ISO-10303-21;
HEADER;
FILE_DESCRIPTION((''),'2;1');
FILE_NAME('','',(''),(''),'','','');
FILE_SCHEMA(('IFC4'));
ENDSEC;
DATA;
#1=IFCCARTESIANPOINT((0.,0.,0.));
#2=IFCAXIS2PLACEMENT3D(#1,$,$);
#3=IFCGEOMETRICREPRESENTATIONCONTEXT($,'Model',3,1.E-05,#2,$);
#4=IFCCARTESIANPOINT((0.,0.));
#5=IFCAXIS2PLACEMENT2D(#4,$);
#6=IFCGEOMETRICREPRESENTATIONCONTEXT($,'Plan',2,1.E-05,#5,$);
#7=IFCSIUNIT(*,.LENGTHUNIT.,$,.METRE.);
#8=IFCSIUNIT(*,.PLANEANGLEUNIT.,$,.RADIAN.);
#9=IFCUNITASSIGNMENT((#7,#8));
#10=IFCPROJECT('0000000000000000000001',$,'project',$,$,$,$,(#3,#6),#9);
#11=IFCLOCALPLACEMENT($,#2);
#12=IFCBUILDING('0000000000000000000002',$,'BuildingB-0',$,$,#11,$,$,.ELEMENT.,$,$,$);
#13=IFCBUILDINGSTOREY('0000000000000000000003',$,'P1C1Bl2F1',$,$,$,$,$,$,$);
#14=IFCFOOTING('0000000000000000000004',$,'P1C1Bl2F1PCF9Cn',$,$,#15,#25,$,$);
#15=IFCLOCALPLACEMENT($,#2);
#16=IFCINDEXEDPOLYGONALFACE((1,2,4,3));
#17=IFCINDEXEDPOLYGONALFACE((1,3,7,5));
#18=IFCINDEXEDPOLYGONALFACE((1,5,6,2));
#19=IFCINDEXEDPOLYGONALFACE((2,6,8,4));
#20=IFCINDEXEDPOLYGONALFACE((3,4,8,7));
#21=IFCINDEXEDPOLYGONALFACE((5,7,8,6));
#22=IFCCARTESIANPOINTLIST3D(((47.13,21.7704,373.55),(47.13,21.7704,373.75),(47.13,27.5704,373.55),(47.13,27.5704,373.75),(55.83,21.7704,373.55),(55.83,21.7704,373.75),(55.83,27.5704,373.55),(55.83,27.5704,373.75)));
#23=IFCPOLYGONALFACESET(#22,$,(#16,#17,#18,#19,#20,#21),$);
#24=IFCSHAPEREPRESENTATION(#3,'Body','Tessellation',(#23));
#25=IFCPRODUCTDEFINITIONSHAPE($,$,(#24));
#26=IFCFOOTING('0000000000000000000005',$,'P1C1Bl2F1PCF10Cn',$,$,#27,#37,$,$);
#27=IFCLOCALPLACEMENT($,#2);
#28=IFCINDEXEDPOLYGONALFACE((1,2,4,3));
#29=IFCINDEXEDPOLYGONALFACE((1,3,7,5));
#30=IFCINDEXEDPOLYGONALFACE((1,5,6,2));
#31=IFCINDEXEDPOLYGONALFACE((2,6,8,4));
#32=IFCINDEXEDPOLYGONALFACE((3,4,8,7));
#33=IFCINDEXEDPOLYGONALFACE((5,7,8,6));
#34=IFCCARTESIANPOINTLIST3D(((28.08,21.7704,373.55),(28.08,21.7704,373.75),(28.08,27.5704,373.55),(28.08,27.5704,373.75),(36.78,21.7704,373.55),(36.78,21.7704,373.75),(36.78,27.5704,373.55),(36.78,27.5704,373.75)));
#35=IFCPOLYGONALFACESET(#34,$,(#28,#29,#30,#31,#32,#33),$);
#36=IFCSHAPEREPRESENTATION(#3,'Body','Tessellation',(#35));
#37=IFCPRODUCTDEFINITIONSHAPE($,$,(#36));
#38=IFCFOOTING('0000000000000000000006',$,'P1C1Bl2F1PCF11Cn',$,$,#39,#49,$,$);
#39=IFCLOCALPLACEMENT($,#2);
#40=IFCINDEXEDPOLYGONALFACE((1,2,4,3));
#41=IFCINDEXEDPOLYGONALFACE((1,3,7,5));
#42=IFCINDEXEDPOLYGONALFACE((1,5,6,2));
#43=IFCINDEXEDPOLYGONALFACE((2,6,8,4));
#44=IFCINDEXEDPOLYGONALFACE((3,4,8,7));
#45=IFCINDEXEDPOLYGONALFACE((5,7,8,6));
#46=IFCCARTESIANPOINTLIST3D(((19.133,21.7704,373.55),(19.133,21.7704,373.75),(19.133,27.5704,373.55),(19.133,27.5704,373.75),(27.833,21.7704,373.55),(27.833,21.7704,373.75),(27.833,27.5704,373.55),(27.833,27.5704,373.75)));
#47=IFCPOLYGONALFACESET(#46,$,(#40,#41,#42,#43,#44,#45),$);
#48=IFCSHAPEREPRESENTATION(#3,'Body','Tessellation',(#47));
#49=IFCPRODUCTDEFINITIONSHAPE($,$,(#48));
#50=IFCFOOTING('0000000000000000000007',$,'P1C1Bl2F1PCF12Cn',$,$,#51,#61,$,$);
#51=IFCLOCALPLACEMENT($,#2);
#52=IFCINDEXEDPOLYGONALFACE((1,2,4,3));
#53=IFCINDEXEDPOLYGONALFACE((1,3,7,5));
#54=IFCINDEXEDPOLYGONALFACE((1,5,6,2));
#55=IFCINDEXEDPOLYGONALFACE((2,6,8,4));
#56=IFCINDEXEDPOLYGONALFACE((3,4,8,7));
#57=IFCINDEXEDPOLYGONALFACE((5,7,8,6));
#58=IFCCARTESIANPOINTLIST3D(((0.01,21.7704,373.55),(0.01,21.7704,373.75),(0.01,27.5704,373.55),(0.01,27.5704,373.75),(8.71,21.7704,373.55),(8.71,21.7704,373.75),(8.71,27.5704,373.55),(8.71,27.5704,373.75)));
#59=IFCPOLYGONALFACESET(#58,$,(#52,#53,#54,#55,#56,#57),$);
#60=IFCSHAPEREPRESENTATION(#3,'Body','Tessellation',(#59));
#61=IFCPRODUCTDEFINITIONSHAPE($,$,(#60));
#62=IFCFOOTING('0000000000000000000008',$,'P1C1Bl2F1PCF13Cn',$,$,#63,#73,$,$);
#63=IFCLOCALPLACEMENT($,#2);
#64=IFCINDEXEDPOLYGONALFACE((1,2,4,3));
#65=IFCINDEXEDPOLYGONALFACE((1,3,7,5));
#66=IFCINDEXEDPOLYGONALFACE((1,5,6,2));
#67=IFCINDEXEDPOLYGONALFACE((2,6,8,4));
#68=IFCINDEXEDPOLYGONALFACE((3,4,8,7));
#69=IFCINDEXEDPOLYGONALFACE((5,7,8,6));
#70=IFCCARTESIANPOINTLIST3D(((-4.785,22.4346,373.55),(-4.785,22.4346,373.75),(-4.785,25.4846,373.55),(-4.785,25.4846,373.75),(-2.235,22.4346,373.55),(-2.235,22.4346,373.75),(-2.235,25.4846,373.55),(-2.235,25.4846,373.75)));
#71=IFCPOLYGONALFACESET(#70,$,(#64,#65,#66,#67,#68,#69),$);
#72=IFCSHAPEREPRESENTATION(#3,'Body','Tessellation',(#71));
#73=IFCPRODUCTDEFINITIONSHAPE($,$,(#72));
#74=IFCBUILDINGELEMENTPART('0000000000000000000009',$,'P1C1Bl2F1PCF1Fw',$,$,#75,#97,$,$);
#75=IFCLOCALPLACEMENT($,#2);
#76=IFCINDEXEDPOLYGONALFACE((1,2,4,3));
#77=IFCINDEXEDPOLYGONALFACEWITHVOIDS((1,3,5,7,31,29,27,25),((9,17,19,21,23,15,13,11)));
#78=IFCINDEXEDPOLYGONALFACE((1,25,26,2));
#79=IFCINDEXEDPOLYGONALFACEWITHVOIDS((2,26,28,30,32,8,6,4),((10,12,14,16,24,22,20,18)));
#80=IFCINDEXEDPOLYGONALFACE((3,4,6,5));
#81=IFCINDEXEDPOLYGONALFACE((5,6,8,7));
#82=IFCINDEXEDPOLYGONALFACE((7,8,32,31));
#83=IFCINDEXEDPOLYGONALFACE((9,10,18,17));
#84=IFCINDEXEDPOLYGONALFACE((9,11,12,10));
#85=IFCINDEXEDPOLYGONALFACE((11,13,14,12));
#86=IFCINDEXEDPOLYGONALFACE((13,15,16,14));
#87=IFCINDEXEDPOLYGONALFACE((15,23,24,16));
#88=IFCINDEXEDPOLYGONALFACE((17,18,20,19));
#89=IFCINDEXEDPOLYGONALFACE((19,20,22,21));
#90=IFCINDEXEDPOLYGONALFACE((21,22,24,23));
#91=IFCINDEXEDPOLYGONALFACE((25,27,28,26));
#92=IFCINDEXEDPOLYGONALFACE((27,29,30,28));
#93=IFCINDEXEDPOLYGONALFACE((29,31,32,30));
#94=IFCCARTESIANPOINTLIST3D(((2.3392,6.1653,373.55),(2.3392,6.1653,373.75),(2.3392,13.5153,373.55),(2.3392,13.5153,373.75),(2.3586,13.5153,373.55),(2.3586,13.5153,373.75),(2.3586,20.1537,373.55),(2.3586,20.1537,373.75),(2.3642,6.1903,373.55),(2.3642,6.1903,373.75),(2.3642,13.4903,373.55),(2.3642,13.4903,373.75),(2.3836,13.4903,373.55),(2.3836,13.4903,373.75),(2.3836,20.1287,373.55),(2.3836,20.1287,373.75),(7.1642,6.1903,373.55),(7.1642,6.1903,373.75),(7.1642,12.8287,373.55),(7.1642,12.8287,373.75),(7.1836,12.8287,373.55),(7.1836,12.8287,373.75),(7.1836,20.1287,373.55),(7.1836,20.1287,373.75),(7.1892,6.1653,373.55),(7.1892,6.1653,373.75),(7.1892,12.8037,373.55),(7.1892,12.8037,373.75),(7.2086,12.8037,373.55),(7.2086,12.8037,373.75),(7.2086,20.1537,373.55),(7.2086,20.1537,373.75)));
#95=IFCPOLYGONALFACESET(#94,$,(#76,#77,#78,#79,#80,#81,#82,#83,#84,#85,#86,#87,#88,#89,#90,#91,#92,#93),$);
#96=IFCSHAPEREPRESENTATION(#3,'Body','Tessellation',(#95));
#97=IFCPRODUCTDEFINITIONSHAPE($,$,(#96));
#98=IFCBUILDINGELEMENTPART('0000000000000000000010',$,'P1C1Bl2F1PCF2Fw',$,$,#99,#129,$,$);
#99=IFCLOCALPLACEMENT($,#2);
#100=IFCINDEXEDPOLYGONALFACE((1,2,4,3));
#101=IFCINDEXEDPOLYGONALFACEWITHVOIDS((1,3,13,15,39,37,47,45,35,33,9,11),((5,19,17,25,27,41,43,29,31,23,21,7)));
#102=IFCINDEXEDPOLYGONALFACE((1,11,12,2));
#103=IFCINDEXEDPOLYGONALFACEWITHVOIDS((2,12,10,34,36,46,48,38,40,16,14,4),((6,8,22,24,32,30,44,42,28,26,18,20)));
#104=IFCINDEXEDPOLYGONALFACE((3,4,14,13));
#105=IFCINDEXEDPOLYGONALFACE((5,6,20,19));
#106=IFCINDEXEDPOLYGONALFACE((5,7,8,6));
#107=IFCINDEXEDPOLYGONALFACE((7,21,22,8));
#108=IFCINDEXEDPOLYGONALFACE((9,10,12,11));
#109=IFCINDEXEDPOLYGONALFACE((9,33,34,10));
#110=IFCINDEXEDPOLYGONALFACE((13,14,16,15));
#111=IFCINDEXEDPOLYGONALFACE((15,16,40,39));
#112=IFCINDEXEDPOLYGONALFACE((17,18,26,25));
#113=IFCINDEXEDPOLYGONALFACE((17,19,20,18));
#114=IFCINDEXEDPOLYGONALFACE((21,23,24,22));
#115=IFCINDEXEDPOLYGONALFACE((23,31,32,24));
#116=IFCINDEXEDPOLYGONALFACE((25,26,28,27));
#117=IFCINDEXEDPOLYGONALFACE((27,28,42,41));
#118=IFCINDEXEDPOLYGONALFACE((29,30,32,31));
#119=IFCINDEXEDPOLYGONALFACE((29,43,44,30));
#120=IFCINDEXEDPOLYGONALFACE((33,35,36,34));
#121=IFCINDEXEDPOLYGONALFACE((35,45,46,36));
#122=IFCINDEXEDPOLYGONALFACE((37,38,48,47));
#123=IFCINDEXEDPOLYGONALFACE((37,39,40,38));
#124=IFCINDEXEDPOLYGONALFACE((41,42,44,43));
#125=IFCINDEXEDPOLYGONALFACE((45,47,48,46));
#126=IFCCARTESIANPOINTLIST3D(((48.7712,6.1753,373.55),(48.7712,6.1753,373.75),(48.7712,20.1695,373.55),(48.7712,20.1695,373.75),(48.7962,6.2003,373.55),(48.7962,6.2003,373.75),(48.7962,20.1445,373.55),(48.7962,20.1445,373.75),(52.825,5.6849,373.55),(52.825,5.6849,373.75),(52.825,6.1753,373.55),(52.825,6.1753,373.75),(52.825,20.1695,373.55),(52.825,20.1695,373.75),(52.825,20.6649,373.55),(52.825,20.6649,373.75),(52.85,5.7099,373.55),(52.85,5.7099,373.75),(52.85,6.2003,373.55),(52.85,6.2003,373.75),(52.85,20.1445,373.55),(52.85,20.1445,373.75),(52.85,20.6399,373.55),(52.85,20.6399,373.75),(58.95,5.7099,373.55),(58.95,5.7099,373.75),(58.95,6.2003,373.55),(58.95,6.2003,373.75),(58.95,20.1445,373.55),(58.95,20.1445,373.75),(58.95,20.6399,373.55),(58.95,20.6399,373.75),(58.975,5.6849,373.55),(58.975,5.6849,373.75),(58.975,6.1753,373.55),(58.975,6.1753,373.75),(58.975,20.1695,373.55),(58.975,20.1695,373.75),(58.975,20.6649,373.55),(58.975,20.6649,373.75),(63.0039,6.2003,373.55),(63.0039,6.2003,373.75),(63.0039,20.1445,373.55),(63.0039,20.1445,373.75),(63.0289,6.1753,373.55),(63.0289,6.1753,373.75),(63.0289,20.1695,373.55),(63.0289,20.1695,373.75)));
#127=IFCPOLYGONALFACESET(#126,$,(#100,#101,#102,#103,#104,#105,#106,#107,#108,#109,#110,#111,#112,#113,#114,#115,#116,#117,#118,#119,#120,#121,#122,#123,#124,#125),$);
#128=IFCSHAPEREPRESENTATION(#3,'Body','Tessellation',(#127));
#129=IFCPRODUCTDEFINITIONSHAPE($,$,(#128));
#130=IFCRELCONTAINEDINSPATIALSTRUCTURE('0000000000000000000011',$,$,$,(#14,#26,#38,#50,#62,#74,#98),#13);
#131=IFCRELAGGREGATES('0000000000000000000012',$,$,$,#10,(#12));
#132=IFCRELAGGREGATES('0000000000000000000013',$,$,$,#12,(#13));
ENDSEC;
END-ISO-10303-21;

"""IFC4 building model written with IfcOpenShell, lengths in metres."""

from ifc_helpers import new_model, si_unit, origin, origin_2d, place, context, project, spatial, polyline, outline, extrude, element, save


model = new_model("IFC4")

# Units and contexts
model_context = context("Model", 3, precision=1e-05, world=origin())
plan_context = context("Plan", 2, precision=1e-05, world=origin_2d())
ifc_project = project(units=[si_unit("LENGTHUNIT", "METRE"), si_unit("PLANEANGLEUNIT", "RADIAN")], contexts=[model_context, plan_context])

# Building, storey
building_placement = place(None, origin())
building = spatial("IfcBuilding", under=ifc_project, at=building_placement, Name="BuildingB-0", CompositionType="ELEMENT")
storey = spatial("IfcBuildingStorey", under=building, Name="P1C1Bl2F1")

# Footings
element("IfcFooting", 1, inside=storey, Name="P1C1Bl2F1PCF9Cn", context=model_context, shape_type="SweptSolid", body=[
    extrude(outline(polyline([(47.13, 21.7704, 373.55), (55.83, 21.7704, 373.55), (55.83, 27.5704, 373.55), (47.13, 27.5704, 373.55), (47.13, 21.7704, 373.55)])), None, (0.0, 0.0, 1.0), 0.2),
])
element("IfcFooting", 2, inside=storey, Name="P1C1Bl2F1PCF10Cn", context=model_context, shape_type="SweptSolid", body=[
    extrude(outline(polyline([(28.08, 21.7704, 373.55), (36.78, 21.7704, 373.55), (36.78, 27.5704, 373.55), (28.08, 27.5704, 373.55), (28.08, 21.7704, 373.55)])), None, (0.0, 0.0, 1.0), 0.2),
])
element("IfcFooting", 3, inside=storey, Name="P1C1Bl2F1PCF11Cn", context=model_context, shape_type="SweptSolid", body=[
    extrude(outline(polyline([(27.833, 27.5704, 373.55), (19.133, 27.5704, 373.55), (19.133, 21.7704, 373.55), (27.833, 21.7704, 373.55), (27.833, 27.5704, 373.55)])), None, (0.0, 0.0, 1.0), 0.2),
])
element("IfcFooting", 4, inside=storey, Name="P1C1Bl2F1PCF12Cn", context=model_context, shape_type="SweptSolid", body=[
    extrude(outline(polyline([(8.71, 27.5704, 373.55), (0.01, 27.5704, 373.55), (0.01, 21.7704, 373.55), (8.71, 21.7704, 373.55), (8.71, 27.5704, 373.55)])), None, (0.0, 0.0, 1.0), 0.2),
])
element("IfcFooting", 5, inside=storey, Name="P1C1Bl2F1PCF13Cn", context=model_context, shape_type="SweptSolid", body=[
    extrude(outline(polyline([(-2.235, 25.4846, 373.55), (-4.785, 25.4846, 373.55), (-4.785, 22.4346, 373.55), (-2.235, 22.4346, 373.55), (-2.235, 25.4846, 373.55)])), None, (0.0, 0.0, 1.0), 0.2),
])

# Building element parts, openings
building_element_part_1 = element("IfcBuildingElementPart", 6, inside=storey, Name="P1C1Bl2F1PCF1Fw", context=model_context, shape_type="SweptSolid", body=[
    extrude(outline(polyline([(7.1892, 12.8037, 373.55), (7.2086, 12.8037, 373.55), (7.2086, 15.1899, 373.55), (7.2086, 20.1537, 373.55), (2.3586, 20.1537, 373.55), (2.3586, 17.04, 373.55), (2.3586, 13.5153, 373.55), (2.3392, 13.5153, 373.55), (2.3392, 9.16, 373.55), (2.3392, 6.1653, 373.55), (5.3245, 6.1653, 373.55), (7.1892, 6.1653, 373.55), (7.1892, 9.3099, 373.55), (7.1892, 12.8037, 373.55)])), None, (0.0, 0.0, 1.0), 0.2),
])
element("IfcOpeningElement", 7, inside=storey, cuts=building_element_part_1, context=model_context, shape_type="SweptSolid", body=[
    extrude(outline(polyline([(7.1642, 12.8287, 373.55), (7.1836, 12.8287, 373.55), (7.1836, 15.1899, 373.55), (7.1836, 20.1287, 373.55), (2.3836, 20.1287, 373.55), (2.3836, 17.04, 373.55), (2.3836, 13.4903, 373.55), (2.3642, 13.4903, 373.55), (2.3642, 9.16, 373.55), (2.3642, 6.1903, 373.55), (5.3245, 6.1903, 373.55), (7.1642, 6.1903, 373.55), (7.1642, 9.3099, 373.55), (7.1642, 12.8287, 373.55)])), None, (0.0, 0.0, 1.0), 0.2),
])
building_element_part_2 = element("IfcBuildingElementPart", 8, inside=storey, Name="P1C1Bl2F1PCF2Fw", context=model_context, shape_type="SweptSolid", body=[
    extrude(outline(polyline([(58.975, 5.6849, 373.55), (58.975, 6.1753, 373.55), (63.0289, 6.1753, 373.55), (63.0289, 20.1695, 373.55), (58.975, 20.1695, 373.55), (58.975, 20.6649, 373.55), (56.5291, 20.6649, 373.55), (54.9522, 20.6649, 373.55), (52.825, 20.6649, 373.55), (52.825, 20.1695, 373.55), (48.7712, 20.1695, 373.55), (48.7712, 6.1753, 373.55), (52.825, 6.1753, 373.55), (52.825, 5.6849, 373.55), (58.975, 5.6849, 373.55)])), None, (0.0, 0.0, 1.0), 0.2),
])
element("IfcOpeningElement", 9, inside=storey, cuts=building_element_part_2, context=model_context, shape_type="SweptSolid", body=[
    extrude(outline(polyline([(58.95, 5.7099, 373.55), (58.95, 6.2003, 373.55), (63.0039, 6.2003, 373.55), (63.0039, 20.1445, 373.55), (58.95, 20.1445, 373.55), (58.95, 20.6399, 373.55), (56.5291, 20.6399, 373.55), (54.9522, 20.6399, 373.55), (52.85, 20.6399, 373.55), (52.85, 20.1445, 373.55), (48.7962, 20.1445, 373.55), (48.7962, 6.2003, 373.55), (52.85, 6.2003, 373.55), (52.85, 5.7099, 373.55), (58.95, 5.7099, 373.55)])), None, (0.0, 0.0, 1.0), 0.2),
])

save(model, "model.ifc")
